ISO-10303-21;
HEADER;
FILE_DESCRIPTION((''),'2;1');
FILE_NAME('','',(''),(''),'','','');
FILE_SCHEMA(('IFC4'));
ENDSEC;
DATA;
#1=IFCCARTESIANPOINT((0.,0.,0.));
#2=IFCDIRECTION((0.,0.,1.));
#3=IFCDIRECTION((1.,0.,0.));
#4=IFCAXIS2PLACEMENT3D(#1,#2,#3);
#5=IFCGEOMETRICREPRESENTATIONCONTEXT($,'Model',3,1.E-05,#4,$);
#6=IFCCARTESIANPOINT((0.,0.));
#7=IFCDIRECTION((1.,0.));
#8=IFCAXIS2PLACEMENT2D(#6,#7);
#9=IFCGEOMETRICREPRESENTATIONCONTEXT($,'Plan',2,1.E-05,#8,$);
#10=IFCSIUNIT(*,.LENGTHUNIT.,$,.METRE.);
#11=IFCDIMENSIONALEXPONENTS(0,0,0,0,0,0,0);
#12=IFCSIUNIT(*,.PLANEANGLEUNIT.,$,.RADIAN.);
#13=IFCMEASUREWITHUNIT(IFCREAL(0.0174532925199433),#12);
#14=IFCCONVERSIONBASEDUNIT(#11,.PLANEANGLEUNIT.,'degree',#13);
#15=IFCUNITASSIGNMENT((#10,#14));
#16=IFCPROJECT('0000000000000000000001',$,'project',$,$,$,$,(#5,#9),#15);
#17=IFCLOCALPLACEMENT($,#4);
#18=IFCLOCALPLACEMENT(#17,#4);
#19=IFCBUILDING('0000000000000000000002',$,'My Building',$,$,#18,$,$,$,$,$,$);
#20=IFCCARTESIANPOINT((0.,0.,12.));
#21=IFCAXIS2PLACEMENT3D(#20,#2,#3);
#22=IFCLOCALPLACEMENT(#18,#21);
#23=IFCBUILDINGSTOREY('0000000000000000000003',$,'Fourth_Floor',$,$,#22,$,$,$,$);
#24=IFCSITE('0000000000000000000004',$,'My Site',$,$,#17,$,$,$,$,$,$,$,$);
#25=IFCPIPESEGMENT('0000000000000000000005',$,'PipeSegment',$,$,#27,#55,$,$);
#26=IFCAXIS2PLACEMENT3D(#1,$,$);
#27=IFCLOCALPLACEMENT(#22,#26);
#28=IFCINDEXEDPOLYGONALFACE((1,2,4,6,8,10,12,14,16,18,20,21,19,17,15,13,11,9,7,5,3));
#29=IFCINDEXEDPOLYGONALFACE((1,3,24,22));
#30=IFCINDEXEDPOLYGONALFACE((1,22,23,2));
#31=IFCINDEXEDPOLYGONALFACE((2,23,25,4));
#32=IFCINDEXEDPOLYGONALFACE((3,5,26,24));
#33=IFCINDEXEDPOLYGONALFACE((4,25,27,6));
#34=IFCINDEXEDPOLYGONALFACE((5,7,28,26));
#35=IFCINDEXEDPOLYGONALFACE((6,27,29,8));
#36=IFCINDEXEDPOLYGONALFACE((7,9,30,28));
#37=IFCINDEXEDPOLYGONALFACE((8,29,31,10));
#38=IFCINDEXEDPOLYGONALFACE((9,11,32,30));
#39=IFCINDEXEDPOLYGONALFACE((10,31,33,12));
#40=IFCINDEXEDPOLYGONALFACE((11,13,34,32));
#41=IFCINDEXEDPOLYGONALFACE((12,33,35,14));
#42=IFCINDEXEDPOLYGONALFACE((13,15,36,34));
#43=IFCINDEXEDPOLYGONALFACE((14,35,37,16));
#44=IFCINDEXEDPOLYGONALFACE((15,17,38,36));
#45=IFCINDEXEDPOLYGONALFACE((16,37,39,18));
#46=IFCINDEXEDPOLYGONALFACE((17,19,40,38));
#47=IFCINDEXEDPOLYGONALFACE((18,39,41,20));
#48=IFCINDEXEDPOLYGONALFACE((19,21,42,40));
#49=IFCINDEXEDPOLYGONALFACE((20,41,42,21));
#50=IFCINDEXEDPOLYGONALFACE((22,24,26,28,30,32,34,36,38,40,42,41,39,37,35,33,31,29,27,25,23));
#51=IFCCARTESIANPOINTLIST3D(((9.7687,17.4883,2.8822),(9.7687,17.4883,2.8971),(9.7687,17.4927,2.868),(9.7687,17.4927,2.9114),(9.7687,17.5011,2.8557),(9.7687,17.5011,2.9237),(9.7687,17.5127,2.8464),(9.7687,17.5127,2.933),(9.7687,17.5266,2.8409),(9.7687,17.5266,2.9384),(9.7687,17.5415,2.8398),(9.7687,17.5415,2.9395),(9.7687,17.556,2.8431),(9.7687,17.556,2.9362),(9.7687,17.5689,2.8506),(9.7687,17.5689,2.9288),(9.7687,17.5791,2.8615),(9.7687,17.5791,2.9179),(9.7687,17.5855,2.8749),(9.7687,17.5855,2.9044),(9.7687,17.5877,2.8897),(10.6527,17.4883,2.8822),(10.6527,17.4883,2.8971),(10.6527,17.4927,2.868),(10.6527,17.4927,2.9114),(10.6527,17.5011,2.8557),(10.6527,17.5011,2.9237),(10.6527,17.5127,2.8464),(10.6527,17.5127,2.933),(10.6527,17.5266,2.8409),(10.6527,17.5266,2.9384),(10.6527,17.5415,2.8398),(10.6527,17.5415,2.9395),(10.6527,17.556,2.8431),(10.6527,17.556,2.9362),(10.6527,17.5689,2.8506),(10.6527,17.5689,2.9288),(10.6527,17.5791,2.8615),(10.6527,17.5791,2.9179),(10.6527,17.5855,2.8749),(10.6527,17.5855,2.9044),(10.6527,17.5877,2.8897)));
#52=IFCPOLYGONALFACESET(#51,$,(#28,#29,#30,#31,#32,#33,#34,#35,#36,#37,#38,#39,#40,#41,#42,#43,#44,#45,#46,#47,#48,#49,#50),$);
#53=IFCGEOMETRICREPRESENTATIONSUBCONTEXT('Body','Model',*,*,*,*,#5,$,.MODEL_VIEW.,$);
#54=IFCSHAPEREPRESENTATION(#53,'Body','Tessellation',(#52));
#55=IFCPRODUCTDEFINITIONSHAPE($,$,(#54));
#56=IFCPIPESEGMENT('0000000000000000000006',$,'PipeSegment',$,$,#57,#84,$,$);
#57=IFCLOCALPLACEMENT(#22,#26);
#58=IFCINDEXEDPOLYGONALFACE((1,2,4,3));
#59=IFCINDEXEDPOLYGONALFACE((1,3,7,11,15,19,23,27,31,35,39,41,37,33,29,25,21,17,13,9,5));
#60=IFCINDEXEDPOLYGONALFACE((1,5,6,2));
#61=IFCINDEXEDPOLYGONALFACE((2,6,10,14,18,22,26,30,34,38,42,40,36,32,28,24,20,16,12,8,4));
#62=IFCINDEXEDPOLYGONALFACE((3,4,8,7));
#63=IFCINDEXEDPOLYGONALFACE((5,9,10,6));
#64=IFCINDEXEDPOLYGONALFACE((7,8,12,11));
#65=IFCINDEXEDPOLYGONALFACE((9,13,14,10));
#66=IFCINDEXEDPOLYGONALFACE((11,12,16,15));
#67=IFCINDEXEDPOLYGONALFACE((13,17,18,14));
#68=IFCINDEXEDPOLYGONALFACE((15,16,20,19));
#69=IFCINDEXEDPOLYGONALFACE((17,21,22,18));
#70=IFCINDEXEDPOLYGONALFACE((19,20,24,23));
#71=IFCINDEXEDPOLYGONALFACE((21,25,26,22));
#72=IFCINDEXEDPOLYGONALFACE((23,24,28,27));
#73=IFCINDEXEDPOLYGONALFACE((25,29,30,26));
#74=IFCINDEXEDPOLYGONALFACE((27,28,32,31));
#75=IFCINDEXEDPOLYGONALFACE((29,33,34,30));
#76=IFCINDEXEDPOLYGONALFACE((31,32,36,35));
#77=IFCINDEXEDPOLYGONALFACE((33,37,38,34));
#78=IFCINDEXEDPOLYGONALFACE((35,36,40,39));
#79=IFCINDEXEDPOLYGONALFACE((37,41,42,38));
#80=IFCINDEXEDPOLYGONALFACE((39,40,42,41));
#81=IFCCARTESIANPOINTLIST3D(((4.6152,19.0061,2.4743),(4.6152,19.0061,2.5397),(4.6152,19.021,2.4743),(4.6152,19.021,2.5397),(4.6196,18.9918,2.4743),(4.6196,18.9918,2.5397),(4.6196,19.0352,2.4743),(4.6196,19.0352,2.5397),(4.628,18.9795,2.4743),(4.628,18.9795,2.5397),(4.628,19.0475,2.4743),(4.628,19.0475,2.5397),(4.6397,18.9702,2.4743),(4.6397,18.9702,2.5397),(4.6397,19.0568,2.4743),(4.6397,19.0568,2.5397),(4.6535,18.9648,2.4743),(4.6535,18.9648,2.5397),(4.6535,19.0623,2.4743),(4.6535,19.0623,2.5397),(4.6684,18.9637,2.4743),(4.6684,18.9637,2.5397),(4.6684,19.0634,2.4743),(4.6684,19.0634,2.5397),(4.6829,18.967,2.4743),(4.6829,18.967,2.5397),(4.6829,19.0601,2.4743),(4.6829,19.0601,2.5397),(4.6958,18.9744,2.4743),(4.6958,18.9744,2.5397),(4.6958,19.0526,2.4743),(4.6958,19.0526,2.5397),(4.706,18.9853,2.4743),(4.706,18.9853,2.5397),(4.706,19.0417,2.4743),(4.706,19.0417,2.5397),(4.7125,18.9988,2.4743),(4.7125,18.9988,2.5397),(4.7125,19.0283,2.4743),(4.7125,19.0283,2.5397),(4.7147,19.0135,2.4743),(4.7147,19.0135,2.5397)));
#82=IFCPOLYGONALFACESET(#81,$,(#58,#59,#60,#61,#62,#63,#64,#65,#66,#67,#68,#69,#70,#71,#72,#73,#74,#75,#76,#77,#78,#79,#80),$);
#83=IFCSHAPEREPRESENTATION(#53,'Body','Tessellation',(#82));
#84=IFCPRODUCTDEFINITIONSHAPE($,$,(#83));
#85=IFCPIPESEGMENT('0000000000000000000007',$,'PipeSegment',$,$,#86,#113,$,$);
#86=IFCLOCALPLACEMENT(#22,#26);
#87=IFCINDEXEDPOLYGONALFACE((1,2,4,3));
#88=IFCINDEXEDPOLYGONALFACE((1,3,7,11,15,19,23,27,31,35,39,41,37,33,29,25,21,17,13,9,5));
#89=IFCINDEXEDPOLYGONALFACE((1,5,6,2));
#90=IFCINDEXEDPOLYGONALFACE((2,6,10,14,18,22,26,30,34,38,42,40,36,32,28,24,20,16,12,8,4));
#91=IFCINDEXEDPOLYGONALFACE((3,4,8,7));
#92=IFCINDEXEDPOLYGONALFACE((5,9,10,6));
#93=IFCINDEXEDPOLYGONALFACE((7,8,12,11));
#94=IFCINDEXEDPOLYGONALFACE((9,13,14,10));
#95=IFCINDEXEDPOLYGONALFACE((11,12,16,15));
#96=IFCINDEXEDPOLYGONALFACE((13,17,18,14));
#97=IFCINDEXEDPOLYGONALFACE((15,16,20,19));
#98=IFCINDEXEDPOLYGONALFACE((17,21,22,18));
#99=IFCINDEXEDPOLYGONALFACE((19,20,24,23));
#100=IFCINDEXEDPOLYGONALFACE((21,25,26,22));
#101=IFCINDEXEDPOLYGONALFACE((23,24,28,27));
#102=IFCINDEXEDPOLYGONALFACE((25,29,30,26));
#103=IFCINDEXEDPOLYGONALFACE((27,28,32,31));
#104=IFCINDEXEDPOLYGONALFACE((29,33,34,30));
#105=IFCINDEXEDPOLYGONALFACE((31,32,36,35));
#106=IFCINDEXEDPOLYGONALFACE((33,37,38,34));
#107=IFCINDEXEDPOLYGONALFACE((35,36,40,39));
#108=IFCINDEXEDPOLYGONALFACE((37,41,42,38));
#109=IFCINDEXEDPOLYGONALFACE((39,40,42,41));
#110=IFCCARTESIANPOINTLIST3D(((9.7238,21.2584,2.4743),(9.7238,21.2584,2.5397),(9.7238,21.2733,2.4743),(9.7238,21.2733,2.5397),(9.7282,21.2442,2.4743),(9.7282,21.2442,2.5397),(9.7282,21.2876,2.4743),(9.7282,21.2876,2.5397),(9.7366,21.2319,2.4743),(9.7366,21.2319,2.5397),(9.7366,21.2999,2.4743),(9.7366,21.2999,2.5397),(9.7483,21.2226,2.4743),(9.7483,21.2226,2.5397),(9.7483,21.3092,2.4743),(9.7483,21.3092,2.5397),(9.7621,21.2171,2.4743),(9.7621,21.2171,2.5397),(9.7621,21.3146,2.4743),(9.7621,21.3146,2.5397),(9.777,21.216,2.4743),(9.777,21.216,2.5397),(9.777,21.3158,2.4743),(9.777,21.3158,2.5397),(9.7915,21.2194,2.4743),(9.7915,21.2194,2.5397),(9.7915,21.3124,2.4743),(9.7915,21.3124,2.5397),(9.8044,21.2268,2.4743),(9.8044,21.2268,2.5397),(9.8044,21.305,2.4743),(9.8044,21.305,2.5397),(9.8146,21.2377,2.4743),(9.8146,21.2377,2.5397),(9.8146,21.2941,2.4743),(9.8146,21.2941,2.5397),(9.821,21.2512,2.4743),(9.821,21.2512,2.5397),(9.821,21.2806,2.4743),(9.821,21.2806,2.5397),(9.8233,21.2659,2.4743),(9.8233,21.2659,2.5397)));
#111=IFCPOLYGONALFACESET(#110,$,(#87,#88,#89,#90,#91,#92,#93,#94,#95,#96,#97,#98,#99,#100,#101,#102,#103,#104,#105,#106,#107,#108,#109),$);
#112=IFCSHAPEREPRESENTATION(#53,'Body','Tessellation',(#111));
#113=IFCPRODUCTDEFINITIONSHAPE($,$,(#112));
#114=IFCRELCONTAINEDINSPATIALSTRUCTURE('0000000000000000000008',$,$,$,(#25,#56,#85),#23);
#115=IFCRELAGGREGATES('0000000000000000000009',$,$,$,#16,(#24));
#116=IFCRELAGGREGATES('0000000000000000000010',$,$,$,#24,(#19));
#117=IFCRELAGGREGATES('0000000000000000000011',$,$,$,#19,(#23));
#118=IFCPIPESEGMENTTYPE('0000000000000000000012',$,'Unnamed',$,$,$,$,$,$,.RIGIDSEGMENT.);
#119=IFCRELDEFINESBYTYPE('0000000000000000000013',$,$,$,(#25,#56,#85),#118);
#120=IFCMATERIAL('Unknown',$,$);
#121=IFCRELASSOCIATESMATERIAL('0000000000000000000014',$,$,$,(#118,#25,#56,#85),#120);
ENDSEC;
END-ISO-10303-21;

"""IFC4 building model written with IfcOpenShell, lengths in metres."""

from ifc_helpers import new_model, entity, si_unit, converted_unit, frame, origin_with_axes, origin_2d_with_axis, place, context, subcontext, project, spatial, circle, extrude, material, material_profile, profile_set, profile_usage, type_object, element, save


model = new_model("IFC4")

# Units and contexts
model_context = context("Model", 3, precision=1e-05, world=origin_with_axes())
plan_context = context("Plan", 2, precision=1e-05, world=origin_2d_with_axis())
body_context_1 = subcontext(model_context, "Body", "Model", "MODEL_VIEW")
ifc_project = project(units=[si_unit("LENGTHUNIT", "METRE"), converted_unit("PLANEANGLEUNIT", "degree", entity("IfcReal", 0.0174532925199433), si_unit("PLANEANGLEUNIT", "RADIAN"), dimensions=[0, 0, 0, 0, 0, 0, 0])], contexts=[model_context, plan_context])

# Site, building, storey
site_placement = place(None, origin_with_axes())
site = spatial("IfcSite", under=ifc_project, at=site_placement, Name="My Site")
building_placement = place(site_placement, origin_with_axes())
building = spatial("IfcBuilding", under=site, at=building_placement, Name="My Building")
storey_placement = place(building_placement, frame((0.0, 0.0, 12.0), z_axis=(0.0, 0.0, 1.0), x_axis=(1.0, 0.0, 0.0)))
storey = spatial("IfcBuildingStorey", under=building, at=storey_placement, Name="Fourth_Floor")

# Shared definitions
ifc_material = material(Name="Unknown")

# Pipe segments
ifc_material_profile_1 = material_profile(ifc_material, circle(Radius=0.05))
ifc_profile_set_1 = profile_set([ifc_material_profile_1])
pipe_segment_type = type_object("IfcPipeSegmentType", Name="Unnamed", PredefinedType="RIGIDSEGMENT", material=ifc_profile_set_1)
ifc_profile_usage_1 = profile_usage(ifc_profile_set_1, cardinal=5)
pipe_segment_1_placement = place(storey_placement, frame((9.7687, 17.5377, 2.8897), z_axis=(1.0, 0.0, 0.0), x_axis=(0.0, 1.0, 0.0)))
element("IfcPipeSegment", 1, at=pipe_segment_1_placement, inside=storey, type_object=pipe_segment_type, material=ifc_profile_usage_1, Name="PipeSegment", context=body_context_1, shape_type="SweptSolid", body=[
    extrude(circle(Radius=0.05), origin_with_axes(), (0.0, 0.0, 1.0), 0.884),
])
ifc_profile_usage_2 = profile_usage(ifc_profile_set_1, cardinal=5)
pipe_segment_2_placement = place(storey_placement, frame((4.6647, 19.0135, 2.4743), z_axis=(0.0, 0.0, 1.0), x_axis=(1.0, 0.000001, 0.0)))
element("IfcPipeSegment", 2, at=pipe_segment_2_placement, inside=storey, type_object=pipe_segment_type, material=ifc_profile_usage_2, Name="PipeSegment", context=body_context_1, shape_type="SweptSolid", body=[
    extrude(circle(Radius=0.05), origin_with_axes(), (0.0, 0.0, 1.0), 0.0654),
])
ifc_profile_usage_3 = profile_usage(ifc_profile_set_1, cardinal=5)
pipe_segment_3_placement = place(storey_placement, frame((9.7733, 21.2659, 2.4743), z_axis=(0.0, 0.0, 1.0), x_axis=(1.0, 0.000001, 0.0)))
element("IfcPipeSegment", 3, at=pipe_segment_3_placement, inside=storey, type_object=pipe_segment_type, material=ifc_profile_usage_3, Name="PipeSegment", context=body_context_1, shape_type="SweptSolid", body=[
    extrude(circle(Radius=0.05), origin_with_axes(), (0.0, 0.0, 1.0), 0.0654),
])

save(model, "model.ifc")
